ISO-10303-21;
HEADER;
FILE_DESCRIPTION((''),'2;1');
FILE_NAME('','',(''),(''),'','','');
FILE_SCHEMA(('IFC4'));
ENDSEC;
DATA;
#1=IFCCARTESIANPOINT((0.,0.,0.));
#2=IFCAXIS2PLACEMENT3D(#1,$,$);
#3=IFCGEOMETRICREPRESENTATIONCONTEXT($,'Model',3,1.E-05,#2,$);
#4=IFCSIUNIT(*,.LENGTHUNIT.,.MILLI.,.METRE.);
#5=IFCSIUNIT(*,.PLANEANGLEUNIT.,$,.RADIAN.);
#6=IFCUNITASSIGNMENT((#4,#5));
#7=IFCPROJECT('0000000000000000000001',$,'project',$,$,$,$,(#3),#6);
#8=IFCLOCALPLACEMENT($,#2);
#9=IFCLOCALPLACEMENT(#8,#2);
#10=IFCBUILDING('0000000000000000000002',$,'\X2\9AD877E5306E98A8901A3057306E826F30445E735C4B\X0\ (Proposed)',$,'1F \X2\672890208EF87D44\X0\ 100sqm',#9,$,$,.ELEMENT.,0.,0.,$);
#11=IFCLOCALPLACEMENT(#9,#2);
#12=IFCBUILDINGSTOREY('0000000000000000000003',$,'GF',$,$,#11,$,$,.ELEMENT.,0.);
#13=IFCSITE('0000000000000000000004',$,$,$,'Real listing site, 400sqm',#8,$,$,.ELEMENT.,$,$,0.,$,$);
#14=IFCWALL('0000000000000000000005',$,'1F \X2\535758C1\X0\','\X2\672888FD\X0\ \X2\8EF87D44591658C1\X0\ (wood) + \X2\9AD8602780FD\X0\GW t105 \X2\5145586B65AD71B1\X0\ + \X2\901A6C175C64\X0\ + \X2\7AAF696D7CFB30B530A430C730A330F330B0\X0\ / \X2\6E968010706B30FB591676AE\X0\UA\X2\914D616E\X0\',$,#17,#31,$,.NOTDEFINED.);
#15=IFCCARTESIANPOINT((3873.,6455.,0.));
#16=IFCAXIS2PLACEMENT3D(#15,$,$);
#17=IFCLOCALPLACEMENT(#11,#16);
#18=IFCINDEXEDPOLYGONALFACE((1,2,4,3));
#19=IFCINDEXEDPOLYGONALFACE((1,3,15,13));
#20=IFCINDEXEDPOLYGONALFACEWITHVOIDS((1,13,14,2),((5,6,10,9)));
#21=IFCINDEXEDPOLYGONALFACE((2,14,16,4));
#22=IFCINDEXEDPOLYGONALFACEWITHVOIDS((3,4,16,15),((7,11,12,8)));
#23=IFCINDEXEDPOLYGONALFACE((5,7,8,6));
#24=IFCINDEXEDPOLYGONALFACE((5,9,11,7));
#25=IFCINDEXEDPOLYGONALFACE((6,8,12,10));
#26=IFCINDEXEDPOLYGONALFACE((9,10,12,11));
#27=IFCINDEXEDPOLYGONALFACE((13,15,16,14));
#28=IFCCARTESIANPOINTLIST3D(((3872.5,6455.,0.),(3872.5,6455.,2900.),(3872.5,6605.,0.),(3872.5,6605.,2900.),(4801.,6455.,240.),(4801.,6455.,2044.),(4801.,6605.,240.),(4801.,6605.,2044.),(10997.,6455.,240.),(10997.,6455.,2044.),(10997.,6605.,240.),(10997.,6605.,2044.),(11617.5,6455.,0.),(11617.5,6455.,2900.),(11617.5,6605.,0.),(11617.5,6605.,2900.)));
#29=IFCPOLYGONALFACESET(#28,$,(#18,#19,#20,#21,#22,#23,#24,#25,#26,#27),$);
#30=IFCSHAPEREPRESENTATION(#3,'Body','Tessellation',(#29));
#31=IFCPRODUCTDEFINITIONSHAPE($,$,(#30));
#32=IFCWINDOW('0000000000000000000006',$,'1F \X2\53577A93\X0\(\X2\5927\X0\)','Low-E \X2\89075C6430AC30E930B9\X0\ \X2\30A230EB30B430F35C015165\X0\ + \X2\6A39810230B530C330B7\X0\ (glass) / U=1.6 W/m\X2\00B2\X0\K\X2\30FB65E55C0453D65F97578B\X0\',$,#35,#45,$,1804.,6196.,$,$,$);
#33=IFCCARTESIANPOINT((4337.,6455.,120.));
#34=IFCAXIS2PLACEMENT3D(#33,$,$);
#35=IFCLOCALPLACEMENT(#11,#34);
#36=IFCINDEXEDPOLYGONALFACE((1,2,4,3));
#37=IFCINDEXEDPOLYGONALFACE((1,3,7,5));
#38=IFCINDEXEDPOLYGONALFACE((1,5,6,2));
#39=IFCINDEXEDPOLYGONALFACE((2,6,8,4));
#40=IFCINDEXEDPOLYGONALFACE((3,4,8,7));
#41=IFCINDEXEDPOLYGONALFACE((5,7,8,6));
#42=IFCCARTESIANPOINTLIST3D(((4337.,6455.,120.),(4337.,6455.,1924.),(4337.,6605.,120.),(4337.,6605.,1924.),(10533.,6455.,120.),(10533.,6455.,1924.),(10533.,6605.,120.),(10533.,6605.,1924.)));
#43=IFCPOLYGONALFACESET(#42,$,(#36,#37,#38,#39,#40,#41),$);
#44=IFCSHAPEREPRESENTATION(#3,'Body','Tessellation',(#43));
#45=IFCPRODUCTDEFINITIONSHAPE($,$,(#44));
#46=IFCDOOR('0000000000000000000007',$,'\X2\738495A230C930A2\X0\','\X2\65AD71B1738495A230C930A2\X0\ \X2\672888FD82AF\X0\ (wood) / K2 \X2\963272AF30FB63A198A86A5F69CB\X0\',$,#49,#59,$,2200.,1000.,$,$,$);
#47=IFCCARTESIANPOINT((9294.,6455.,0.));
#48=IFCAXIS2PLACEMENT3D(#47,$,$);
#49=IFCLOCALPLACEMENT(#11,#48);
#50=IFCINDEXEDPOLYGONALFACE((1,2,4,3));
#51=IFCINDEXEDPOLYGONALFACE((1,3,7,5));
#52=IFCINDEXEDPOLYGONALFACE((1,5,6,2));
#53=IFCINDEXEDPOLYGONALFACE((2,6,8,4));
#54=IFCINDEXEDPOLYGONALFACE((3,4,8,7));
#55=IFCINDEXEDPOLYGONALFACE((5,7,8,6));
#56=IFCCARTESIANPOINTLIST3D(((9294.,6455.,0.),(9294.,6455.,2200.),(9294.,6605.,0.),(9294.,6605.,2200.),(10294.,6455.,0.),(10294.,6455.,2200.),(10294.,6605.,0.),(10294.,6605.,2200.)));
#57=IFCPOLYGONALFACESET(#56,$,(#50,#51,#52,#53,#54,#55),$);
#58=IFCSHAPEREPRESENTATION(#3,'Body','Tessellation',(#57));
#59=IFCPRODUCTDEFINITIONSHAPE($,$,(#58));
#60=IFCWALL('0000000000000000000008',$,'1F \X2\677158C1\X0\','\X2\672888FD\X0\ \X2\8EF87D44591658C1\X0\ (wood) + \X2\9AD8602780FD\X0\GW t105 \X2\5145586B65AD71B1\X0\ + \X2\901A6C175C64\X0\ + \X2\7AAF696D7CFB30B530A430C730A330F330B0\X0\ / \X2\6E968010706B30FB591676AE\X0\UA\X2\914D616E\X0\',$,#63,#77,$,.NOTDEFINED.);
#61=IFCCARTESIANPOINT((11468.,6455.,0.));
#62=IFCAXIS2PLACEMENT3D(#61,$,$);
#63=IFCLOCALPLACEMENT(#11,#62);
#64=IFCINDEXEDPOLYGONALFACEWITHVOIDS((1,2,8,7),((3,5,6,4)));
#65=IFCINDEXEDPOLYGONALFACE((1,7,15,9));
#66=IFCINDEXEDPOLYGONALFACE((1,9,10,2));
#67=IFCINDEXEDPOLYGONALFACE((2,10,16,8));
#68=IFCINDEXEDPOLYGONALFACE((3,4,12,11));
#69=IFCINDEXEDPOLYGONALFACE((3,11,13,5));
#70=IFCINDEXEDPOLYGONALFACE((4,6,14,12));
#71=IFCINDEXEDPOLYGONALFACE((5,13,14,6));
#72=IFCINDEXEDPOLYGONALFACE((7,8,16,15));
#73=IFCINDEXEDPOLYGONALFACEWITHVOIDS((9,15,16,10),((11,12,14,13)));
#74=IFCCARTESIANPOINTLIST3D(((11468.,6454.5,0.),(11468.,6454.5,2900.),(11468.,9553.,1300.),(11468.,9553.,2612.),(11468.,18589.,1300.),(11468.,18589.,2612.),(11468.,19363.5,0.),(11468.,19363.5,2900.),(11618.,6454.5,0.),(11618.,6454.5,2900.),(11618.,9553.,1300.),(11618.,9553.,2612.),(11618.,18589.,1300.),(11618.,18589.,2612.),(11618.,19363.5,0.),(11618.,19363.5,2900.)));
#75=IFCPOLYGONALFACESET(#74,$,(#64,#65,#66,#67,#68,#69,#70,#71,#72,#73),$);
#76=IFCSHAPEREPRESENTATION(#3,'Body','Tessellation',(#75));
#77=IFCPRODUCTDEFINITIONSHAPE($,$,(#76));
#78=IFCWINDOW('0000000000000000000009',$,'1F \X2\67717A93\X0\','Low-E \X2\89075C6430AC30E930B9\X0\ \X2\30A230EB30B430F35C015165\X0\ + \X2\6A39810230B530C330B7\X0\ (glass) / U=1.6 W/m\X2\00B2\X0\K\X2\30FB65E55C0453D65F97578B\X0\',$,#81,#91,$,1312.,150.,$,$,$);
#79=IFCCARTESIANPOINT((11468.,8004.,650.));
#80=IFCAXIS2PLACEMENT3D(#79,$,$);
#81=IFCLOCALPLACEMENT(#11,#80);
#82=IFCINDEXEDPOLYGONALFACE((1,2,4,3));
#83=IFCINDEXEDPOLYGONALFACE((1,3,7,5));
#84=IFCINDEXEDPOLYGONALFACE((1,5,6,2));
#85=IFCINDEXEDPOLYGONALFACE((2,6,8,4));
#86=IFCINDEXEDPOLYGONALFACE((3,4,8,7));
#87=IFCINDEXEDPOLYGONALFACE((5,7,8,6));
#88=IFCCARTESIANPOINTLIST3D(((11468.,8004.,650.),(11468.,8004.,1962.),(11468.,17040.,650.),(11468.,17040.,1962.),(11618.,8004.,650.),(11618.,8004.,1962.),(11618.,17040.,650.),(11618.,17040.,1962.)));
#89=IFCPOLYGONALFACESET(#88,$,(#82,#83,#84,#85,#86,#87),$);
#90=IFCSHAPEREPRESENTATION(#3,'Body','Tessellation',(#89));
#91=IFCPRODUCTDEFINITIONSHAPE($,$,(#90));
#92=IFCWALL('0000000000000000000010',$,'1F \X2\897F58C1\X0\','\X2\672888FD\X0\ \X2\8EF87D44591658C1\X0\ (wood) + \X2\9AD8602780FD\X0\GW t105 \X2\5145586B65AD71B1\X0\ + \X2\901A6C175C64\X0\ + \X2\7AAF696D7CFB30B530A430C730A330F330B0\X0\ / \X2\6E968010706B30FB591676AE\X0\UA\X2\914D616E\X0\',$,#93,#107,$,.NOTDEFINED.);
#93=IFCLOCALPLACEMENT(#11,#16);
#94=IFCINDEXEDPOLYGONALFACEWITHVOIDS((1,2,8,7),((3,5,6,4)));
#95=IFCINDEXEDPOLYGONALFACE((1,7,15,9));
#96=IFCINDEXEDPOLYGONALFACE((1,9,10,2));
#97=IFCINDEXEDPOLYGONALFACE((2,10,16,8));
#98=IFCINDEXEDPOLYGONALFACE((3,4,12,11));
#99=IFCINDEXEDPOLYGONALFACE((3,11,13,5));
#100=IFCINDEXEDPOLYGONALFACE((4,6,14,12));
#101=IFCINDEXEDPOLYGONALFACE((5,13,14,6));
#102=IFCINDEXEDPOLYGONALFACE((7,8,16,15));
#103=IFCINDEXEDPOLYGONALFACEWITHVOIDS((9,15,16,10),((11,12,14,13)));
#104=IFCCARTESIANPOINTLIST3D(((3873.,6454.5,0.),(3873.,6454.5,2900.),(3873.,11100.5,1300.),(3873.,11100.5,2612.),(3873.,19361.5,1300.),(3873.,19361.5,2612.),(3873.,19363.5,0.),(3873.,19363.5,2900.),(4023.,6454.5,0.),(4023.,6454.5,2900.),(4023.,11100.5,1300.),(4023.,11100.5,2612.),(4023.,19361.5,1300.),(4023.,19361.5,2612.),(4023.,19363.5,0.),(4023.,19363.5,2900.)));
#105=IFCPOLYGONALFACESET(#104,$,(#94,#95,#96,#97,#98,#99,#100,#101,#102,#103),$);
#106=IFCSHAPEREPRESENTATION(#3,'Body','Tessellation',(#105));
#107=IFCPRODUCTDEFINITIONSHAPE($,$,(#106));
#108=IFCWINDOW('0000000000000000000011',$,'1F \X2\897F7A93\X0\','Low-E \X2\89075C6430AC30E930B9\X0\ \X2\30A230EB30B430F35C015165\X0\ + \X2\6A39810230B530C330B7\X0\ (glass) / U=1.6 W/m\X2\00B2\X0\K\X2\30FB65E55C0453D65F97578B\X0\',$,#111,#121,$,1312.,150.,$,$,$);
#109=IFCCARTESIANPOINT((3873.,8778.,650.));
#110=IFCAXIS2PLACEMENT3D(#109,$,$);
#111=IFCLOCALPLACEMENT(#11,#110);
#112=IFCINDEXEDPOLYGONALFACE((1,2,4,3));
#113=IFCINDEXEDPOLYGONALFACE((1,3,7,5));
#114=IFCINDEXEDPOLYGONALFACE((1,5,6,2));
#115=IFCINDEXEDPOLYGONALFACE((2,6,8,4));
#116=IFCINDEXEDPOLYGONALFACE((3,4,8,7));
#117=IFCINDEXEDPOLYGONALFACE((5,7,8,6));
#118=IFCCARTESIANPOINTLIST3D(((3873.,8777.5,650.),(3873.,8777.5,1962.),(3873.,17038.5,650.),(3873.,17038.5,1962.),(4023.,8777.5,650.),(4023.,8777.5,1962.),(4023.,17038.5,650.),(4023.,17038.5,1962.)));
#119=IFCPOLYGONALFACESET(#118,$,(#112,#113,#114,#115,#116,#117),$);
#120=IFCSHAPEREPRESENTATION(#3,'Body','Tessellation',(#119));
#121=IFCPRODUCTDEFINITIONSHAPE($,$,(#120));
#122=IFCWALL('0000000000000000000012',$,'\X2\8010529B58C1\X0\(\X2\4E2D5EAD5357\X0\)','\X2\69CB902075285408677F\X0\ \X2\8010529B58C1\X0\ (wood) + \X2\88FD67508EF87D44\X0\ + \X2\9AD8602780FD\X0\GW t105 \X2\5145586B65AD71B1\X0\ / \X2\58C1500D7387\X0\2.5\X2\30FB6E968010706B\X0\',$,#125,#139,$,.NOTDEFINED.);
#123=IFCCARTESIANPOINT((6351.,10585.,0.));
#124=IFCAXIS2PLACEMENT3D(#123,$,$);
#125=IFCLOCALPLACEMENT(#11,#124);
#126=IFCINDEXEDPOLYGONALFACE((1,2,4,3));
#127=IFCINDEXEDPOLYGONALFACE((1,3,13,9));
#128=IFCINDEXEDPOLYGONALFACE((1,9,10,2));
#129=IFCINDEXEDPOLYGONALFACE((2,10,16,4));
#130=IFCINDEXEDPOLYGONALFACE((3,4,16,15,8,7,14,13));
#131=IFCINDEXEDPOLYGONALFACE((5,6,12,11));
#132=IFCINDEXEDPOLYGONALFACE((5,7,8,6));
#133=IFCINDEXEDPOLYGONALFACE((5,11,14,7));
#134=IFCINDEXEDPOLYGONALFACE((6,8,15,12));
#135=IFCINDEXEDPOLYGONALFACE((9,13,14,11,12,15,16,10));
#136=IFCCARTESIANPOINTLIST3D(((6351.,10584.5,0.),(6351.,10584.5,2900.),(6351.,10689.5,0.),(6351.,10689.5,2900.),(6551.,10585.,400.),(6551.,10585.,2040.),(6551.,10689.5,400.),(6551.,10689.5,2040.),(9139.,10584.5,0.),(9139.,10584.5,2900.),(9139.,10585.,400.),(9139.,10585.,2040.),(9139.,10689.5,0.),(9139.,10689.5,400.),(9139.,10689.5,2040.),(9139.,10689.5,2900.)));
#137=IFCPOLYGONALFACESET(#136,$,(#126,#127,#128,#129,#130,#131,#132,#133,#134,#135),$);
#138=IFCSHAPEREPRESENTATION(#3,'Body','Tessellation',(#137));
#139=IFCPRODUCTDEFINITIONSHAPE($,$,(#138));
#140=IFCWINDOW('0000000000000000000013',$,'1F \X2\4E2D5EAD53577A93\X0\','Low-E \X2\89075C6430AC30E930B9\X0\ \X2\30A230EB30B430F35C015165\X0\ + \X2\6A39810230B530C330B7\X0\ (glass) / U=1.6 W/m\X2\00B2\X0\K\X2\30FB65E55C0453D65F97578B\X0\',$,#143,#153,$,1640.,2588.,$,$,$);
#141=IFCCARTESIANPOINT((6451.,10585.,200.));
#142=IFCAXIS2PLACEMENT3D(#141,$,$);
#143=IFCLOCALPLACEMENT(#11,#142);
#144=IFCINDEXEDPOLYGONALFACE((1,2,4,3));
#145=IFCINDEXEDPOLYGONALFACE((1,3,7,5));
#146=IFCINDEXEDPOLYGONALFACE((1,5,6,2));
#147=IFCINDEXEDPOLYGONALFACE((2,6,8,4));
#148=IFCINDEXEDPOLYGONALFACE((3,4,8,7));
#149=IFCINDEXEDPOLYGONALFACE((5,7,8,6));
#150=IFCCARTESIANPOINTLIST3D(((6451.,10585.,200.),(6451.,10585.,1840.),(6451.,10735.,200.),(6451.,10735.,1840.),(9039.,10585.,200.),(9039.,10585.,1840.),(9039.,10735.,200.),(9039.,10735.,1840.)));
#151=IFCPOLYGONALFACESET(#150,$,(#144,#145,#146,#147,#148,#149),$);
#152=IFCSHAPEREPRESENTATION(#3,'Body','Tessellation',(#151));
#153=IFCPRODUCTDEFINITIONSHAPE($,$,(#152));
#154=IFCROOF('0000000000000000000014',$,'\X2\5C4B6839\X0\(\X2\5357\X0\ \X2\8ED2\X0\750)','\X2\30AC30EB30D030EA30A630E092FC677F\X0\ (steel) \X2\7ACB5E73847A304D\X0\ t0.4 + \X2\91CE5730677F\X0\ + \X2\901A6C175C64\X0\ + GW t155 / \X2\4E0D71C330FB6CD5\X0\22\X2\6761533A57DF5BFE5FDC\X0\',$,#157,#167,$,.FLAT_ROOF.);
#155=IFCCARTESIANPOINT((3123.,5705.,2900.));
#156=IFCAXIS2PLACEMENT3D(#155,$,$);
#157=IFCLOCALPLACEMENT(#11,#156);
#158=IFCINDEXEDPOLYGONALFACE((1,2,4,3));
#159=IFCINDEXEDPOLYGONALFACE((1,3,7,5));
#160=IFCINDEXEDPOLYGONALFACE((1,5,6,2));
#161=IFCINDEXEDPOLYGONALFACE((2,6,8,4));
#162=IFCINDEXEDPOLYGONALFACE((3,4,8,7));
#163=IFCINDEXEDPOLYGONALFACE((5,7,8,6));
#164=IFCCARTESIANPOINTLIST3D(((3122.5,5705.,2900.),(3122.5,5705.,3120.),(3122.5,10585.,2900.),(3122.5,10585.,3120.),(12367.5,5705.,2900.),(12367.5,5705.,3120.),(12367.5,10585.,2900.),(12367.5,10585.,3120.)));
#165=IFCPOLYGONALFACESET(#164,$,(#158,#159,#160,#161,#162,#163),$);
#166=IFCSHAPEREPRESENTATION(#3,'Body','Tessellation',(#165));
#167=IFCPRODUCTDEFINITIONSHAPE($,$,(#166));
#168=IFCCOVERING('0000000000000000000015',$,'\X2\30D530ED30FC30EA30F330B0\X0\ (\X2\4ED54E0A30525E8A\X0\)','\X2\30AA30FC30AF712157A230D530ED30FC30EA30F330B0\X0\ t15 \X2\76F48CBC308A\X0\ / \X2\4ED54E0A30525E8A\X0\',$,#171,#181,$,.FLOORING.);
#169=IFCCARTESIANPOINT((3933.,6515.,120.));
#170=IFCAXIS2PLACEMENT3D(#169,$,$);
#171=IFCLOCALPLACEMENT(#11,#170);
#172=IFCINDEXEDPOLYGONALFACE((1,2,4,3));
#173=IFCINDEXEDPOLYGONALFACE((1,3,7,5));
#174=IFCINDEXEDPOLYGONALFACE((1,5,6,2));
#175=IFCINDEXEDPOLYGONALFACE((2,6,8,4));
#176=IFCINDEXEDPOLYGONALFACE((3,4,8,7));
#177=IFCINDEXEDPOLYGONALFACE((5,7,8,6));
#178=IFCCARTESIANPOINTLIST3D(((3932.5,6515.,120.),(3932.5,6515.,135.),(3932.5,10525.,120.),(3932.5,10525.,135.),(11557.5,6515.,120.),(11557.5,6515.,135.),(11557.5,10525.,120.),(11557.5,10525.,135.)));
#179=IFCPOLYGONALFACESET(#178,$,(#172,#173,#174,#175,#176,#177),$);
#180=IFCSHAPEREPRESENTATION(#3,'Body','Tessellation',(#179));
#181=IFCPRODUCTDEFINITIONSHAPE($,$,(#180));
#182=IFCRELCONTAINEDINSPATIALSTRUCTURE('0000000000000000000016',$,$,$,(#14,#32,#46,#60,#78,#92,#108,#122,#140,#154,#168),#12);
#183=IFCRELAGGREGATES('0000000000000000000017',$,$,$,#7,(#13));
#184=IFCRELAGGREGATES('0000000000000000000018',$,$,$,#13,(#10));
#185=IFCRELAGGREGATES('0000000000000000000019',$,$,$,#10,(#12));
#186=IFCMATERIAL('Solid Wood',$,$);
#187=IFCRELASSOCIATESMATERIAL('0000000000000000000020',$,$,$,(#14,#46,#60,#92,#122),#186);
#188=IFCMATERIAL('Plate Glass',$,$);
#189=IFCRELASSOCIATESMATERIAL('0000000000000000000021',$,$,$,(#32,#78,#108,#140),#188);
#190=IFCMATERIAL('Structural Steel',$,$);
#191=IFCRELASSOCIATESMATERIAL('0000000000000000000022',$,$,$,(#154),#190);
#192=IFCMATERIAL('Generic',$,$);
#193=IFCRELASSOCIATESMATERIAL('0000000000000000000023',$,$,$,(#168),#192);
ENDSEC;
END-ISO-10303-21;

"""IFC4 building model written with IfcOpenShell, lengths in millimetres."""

from ifc_helpers import new_model, si_unit, frame, frame_2d, origin, place, context, project, spatial, rectangle, extrude, material, element, fill, save


model = new_model("IFC4")

# Units and contexts
model_context = context("Model", 3, precision=1e-05, world=origin())
ifc_project = project(units=[si_unit("LENGTHUNIT", "METRE", prefix="MILLI"), si_unit("PLANEANGLEUNIT", "RADIAN")], contexts=[model_context])

# Site, building, storey
site_placement = place(None, origin())
site = spatial("IfcSite", under=ifc_project, at=site_placement, ObjectType="Real listing site, 400sqm", CompositionType="ELEMENT", RefElevation=0.0)
building_placement = place(site_placement, origin())
building = spatial("IfcBuilding", under=site, at=building_placement, Name="高知の風通しの良い平屋 (Proposed)", ObjectType="1F 木造軸組 100sqm", CompositionType="ELEMENT", ElevationOfRefHeight=0.0, ElevationOfTerrain=0.0)
storey_placement = place(building_placement, origin())
storey = spatial("IfcBuildingStorey", under=building, at=storey_placement, Name="GF", CompositionType="ELEMENT", Elevation=0.0)

# Shared definitions
ifc_material_1 = material(Name="Solid Wood")

# Wall, openings, window, door
wall_1_placement = place(storey_placement, frame((3873.0, 6455.0, 0.0)))
wall_1 = element("IfcWall", 1, at=wall_1_placement, inside=storey, material=ifc_material_1, Name="1F 南壁", Description="木製 軸組外壁 (wood) + 高性能GW t105 充填断熱 + 通気層 + 窯業系サイディング / 準耐火・外皮UA配慮", PredefinedType="NOTDEFINED", context=model_context, shape_type="SweptSolid", body=[
    extrude(rectangle(XDim=7745.0, YDim=150.0, at=frame_2d((3872.0, 75.0))), frame((3873.0, 6455.0, 0.0)), (0.0, 0.0, 1.0), 2900.0),
])
opening_1_placement = place(storey_placement, frame((4337.0, 6455.0, 120.0)))
opening_1 = element("IfcOpeningElement", 2, at=opening_1_placement, cuts=wall_1, PredefinedType="NOTDEFINED", context=model_context, shape_type="SweptSolid", body=[
    extrude(rectangle(XDim=6196.0, YDim=150.0, at=frame_2d((3098.0, 75.0))), frame((4337.0, 6455.0, 120.0)), (0.0, 0.0, 1.0), 1804.0),
])
opening_2_placement = place(storey_placement, frame((9294.0, 6455.0, 0.0)))
opening_2 = element("IfcOpeningElement", 3, at=opening_2_placement, cuts=wall_1, PredefinedType="NOTDEFINED", context=model_context, shape_type="SweptSolid", body=[
    extrude(rectangle(XDim=1000.0, YDim=150.0, at=frame_2d((500.0, 75.0))), frame((9294.0, 6455.0, 0.0)), (0.0, 0.0, 1.0), 2200.0),
])
ifc_material_2 = material(Name="Plate Glass")
window_1_placement = place(storey_placement, frame((4337.0, 6455.0, 120.0)))
window_1 = element("IfcWindow", 4, at=window_1_placement, inside=storey, material=ifc_material_2, Name="1F 南窓(大)", Description="Low-E 複層ガラス アルゴン封入 + 樹脂サッシ (glass) / U=1.6 W/m²K・日射取得型", OverallHeight=1804.0, OverallWidth=6196.0, context=model_context, shape_type="SweptSolid", body=[
    extrude(rectangle(XDim=6196.0, YDim=150.0, at=frame_2d((3098.0, 75.0))), frame((4337.0, 6455.0, 120.0)), (0.0, 0.0, 1.0), 1804.0),
])
fill(opening_1, window_1)
door_placement = place(storey_placement, frame((9294.0, 6455.0, 0.0)))
door = element("IfcDoor", 5, at=door_placement, inside=storey, material=ifc_material_1, Name="玄関ドア", Description="断熱玄関ドア 木製芯 (wood) / K2 防犯・採風機構", OverallHeight=2200.0, OverallWidth=1000.0, context=model_context, shape_type="SweptSolid", body=[
    extrude(rectangle(XDim=1000.0, YDim=150.0, at=frame_2d((500.0, 75.0))), frame((9294.0, 6455.0, 0.0)), (0.0, 0.0, 1.0), 2200.0),
])
fill(opening_2, door)

# Walls, openings, windows
wall_2_placement = place(storey_placement, frame((11468.0, 6455.0, 0.0)))
wall_2 = element("IfcWall", 6, at=wall_2_placement, inside=storey, material=ifc_material_1, Name="1F 東壁", Description="木製 軸組外壁 (wood) + 高性能GW t105 充填断熱 + 通気層 + 窯業系サイディング / 準耐火・外皮UA配慮", PredefinedType="NOTDEFINED", context=model_context, shape_type="SweptSolid", body=[
    extrude(rectangle(XDim=150.0, YDim=12909.0, at=frame_2d((75.0, 6454.0))), frame((11468.0, 6455.0, 0.0)), (0.0, 0.0, 1.0), 2900.0),
])
opening_3_placement = place(storey_placement, frame((11468.0, 8004.0, 650.0)))
opening_3 = element("IfcOpeningElement", 7, at=opening_3_placement, cuts=wall_2, PredefinedType="NOTDEFINED", context=model_context, shape_type="SweptSolid", body=[
    extrude(rectangle(XDim=150.0, YDim=9036.0, at=frame_2d((75.0, 4518.0))), frame((11468.0, 8004.0, 650.0)), (0.0, 0.0, 1.0), 1312.0),
])
window_2_placement = place(storey_placement, frame((11468.0, 8004.0, 650.0)))
window_2 = element("IfcWindow", 8, at=window_2_placement, inside=storey, material=ifc_material_2, Name="1F 東窓", Description="Low-E 複層ガラス アルゴン封入 + 樹脂サッシ (glass) / U=1.6 W/m²K・日射取得型", OverallHeight=1312.0, OverallWidth=150.0, context=model_context, shape_type="SweptSolid", body=[
    extrude(rectangle(XDim=150.0, YDim=9036.0, at=frame_2d((75.0, 4518.0))), frame((11468.0, 8004.0, 650.0)), (0.0, 0.0, 1.0), 1312.0),
])
fill(opening_3, window_2)
wall_3_placement = place(storey_placement, frame((3873.0, 6455.0, 0.0)))
wall_3 = element("IfcWall", 9, at=wall_3_placement, inside=storey, material=ifc_material_1, Name="1F 西壁", Description="木製 軸組外壁 (wood) + 高性能GW t105 充填断熱 + 通気層 + 窯業系サイディング / 準耐火・外皮UA配慮", PredefinedType="NOTDEFINED", context=model_context, shape_type="SweptSolid", body=[
    extrude(rectangle(XDim=150.0, YDim=12909.0, at=frame_2d((75.0, 6454.0))), frame((3873.0, 6455.0, 0.0)), (0.0, 0.0, 1.0), 2900.0),
])
opening_4_placement = place(storey_placement, frame((3873.0, 8778.0, 650.0)))
opening_4 = element("IfcOpeningElement", 10, at=opening_4_placement, cuts=wall_3, PredefinedType="NOTDEFINED", context=model_context, shape_type="SweptSolid", body=[
    extrude(rectangle(XDim=150.0, YDim=8261.0, at=frame_2d((75.0, 4130.0))), frame((3873.0, 8778.0, 650.0)), (0.0, 0.0, 1.0), 1312.0),
])
window_3_placement = place(storey_placement, frame((3873.0, 8778.0, 650.0)))
window_3 = element("IfcWindow", 11, at=window_3_placement, inside=storey, material=ifc_material_2, Name="1F 西窓", Description="Low-E 複層ガラス アルゴン封入 + 樹脂サッシ (glass) / U=1.6 W/m²K・日射取得型", OverallHeight=1312.0, OverallWidth=150.0, context=model_context, shape_type="SweptSolid", body=[
    extrude(rectangle(XDim=150.0, YDim=8261.0, at=frame_2d((75.0, 4130.0))), frame((3873.0, 8778.0, 650.0)), (0.0, 0.0, 1.0), 1312.0),
])
fill(opening_4, window_3)
wall_4_placement = place(storey_placement, frame((6351.0, 10585.0, 0.0)))
wall_4 = element("IfcWall", 12, at=wall_4_placement, inside=storey, material=ifc_material_1, Name="耐力壁(中庭南)", Description="構造用合板 耐力壁 (wood) + 製材軸組 + 高性能GW t105 充填断熱 / 壁倍率2.5・準耐火", PredefinedType="NOTDEFINED", context=model_context, shape_type="SweptSolid", body=[
    extrude(rectangle(XDim=2788.0, YDim=105.0, at=frame_2d((1394.0, 52.0))), frame((6351.0, 10585.0, 0.0)), (0.0, 0.0, 1.0), 2900.0),
])
opening_5_placement = place(storey_placement, frame((6451.0, 10585.0, 200.0)))
opening_5 = element("IfcOpeningElement", 13, at=opening_5_placement, cuts=wall_4, PredefinedType="NOTDEFINED", context=model_context, shape_type="SweptSolid", body=[
    extrude(rectangle(XDim=2588.0, YDim=150.0, at=frame_2d((1294.0, 75.0))), frame((6451.0, 10585.0, 200.0)), (0.0, 0.0, 1.0), 1640.0),
])
window_4_placement = place(storey_placement, frame((6451.0, 10585.0, 200.0)))
window_4 = element("IfcWindow", 14, at=window_4_placement, inside=storey, material=ifc_material_2, Name="1F 中庭南窓", Description="Low-E 複層ガラス アルゴン封入 + 樹脂サッシ (glass) / U=1.6 W/m²K・日射取得型", OverallHeight=1640.0, OverallWidth=2588.0, context=model_context, shape_type="SweptSolid", body=[
    extrude(rectangle(XDim=2588.0, YDim=150.0, at=frame_2d((1294.0, 75.0))), frame((6451.0, 10585.0, 200.0)), (0.0, 0.0, 1.0), 1640.0),
])
fill(opening_5, window_4)

# Roof
ifc_material_3 = material(Name="Structural Steel")
roof_placement = place(storey_placement, frame((3123.0, 5705.0, 2900.0)))
element("IfcRoof", 15, at=roof_placement, inside=storey, material=ifc_material_3, Name="屋根(南 軒750)", Description="ガルバリウム鋼板 (steel) 立平葺き t0.4 + 野地板 + 通気層 + GW t155 / 不燃・法22条区域対応", PredefinedType="FLAT_ROOF", context=model_context, shape_type="SweptSolid", body=[
    extrude(rectangle(XDim=9245.0, YDim=4880.0, at=frame_2d((4622.0, 2440.0))), frame((3123.0, 5705.0, 2900.0)), (0.0, 0.0, 1.0), 220.0),
])

# Covering
ifc_material_4 = material(Name="Generic")
covering_placement = place(storey_placement, frame((3933.0, 6515.0, 120.0)))
element("IfcCovering", 16, at=covering_placement, inside=storey, material=ifc_material_4, Name="フローリング (仕上げ床)", Description="オーク無垢フローリング t15 直貼り / 仕上げ床", PredefinedType="FLOORING", context=model_context, shape_type="SweptSolid", body=[
    extrude(rectangle(XDim=7625.0, YDim=4010.0, at=frame_2d((3812.0, 2005.0))), frame((3933.0, 6515.0, 120.0)), (0.0, 0.0, 1.0), 15.0),
])

save(model, "model.ifc")
